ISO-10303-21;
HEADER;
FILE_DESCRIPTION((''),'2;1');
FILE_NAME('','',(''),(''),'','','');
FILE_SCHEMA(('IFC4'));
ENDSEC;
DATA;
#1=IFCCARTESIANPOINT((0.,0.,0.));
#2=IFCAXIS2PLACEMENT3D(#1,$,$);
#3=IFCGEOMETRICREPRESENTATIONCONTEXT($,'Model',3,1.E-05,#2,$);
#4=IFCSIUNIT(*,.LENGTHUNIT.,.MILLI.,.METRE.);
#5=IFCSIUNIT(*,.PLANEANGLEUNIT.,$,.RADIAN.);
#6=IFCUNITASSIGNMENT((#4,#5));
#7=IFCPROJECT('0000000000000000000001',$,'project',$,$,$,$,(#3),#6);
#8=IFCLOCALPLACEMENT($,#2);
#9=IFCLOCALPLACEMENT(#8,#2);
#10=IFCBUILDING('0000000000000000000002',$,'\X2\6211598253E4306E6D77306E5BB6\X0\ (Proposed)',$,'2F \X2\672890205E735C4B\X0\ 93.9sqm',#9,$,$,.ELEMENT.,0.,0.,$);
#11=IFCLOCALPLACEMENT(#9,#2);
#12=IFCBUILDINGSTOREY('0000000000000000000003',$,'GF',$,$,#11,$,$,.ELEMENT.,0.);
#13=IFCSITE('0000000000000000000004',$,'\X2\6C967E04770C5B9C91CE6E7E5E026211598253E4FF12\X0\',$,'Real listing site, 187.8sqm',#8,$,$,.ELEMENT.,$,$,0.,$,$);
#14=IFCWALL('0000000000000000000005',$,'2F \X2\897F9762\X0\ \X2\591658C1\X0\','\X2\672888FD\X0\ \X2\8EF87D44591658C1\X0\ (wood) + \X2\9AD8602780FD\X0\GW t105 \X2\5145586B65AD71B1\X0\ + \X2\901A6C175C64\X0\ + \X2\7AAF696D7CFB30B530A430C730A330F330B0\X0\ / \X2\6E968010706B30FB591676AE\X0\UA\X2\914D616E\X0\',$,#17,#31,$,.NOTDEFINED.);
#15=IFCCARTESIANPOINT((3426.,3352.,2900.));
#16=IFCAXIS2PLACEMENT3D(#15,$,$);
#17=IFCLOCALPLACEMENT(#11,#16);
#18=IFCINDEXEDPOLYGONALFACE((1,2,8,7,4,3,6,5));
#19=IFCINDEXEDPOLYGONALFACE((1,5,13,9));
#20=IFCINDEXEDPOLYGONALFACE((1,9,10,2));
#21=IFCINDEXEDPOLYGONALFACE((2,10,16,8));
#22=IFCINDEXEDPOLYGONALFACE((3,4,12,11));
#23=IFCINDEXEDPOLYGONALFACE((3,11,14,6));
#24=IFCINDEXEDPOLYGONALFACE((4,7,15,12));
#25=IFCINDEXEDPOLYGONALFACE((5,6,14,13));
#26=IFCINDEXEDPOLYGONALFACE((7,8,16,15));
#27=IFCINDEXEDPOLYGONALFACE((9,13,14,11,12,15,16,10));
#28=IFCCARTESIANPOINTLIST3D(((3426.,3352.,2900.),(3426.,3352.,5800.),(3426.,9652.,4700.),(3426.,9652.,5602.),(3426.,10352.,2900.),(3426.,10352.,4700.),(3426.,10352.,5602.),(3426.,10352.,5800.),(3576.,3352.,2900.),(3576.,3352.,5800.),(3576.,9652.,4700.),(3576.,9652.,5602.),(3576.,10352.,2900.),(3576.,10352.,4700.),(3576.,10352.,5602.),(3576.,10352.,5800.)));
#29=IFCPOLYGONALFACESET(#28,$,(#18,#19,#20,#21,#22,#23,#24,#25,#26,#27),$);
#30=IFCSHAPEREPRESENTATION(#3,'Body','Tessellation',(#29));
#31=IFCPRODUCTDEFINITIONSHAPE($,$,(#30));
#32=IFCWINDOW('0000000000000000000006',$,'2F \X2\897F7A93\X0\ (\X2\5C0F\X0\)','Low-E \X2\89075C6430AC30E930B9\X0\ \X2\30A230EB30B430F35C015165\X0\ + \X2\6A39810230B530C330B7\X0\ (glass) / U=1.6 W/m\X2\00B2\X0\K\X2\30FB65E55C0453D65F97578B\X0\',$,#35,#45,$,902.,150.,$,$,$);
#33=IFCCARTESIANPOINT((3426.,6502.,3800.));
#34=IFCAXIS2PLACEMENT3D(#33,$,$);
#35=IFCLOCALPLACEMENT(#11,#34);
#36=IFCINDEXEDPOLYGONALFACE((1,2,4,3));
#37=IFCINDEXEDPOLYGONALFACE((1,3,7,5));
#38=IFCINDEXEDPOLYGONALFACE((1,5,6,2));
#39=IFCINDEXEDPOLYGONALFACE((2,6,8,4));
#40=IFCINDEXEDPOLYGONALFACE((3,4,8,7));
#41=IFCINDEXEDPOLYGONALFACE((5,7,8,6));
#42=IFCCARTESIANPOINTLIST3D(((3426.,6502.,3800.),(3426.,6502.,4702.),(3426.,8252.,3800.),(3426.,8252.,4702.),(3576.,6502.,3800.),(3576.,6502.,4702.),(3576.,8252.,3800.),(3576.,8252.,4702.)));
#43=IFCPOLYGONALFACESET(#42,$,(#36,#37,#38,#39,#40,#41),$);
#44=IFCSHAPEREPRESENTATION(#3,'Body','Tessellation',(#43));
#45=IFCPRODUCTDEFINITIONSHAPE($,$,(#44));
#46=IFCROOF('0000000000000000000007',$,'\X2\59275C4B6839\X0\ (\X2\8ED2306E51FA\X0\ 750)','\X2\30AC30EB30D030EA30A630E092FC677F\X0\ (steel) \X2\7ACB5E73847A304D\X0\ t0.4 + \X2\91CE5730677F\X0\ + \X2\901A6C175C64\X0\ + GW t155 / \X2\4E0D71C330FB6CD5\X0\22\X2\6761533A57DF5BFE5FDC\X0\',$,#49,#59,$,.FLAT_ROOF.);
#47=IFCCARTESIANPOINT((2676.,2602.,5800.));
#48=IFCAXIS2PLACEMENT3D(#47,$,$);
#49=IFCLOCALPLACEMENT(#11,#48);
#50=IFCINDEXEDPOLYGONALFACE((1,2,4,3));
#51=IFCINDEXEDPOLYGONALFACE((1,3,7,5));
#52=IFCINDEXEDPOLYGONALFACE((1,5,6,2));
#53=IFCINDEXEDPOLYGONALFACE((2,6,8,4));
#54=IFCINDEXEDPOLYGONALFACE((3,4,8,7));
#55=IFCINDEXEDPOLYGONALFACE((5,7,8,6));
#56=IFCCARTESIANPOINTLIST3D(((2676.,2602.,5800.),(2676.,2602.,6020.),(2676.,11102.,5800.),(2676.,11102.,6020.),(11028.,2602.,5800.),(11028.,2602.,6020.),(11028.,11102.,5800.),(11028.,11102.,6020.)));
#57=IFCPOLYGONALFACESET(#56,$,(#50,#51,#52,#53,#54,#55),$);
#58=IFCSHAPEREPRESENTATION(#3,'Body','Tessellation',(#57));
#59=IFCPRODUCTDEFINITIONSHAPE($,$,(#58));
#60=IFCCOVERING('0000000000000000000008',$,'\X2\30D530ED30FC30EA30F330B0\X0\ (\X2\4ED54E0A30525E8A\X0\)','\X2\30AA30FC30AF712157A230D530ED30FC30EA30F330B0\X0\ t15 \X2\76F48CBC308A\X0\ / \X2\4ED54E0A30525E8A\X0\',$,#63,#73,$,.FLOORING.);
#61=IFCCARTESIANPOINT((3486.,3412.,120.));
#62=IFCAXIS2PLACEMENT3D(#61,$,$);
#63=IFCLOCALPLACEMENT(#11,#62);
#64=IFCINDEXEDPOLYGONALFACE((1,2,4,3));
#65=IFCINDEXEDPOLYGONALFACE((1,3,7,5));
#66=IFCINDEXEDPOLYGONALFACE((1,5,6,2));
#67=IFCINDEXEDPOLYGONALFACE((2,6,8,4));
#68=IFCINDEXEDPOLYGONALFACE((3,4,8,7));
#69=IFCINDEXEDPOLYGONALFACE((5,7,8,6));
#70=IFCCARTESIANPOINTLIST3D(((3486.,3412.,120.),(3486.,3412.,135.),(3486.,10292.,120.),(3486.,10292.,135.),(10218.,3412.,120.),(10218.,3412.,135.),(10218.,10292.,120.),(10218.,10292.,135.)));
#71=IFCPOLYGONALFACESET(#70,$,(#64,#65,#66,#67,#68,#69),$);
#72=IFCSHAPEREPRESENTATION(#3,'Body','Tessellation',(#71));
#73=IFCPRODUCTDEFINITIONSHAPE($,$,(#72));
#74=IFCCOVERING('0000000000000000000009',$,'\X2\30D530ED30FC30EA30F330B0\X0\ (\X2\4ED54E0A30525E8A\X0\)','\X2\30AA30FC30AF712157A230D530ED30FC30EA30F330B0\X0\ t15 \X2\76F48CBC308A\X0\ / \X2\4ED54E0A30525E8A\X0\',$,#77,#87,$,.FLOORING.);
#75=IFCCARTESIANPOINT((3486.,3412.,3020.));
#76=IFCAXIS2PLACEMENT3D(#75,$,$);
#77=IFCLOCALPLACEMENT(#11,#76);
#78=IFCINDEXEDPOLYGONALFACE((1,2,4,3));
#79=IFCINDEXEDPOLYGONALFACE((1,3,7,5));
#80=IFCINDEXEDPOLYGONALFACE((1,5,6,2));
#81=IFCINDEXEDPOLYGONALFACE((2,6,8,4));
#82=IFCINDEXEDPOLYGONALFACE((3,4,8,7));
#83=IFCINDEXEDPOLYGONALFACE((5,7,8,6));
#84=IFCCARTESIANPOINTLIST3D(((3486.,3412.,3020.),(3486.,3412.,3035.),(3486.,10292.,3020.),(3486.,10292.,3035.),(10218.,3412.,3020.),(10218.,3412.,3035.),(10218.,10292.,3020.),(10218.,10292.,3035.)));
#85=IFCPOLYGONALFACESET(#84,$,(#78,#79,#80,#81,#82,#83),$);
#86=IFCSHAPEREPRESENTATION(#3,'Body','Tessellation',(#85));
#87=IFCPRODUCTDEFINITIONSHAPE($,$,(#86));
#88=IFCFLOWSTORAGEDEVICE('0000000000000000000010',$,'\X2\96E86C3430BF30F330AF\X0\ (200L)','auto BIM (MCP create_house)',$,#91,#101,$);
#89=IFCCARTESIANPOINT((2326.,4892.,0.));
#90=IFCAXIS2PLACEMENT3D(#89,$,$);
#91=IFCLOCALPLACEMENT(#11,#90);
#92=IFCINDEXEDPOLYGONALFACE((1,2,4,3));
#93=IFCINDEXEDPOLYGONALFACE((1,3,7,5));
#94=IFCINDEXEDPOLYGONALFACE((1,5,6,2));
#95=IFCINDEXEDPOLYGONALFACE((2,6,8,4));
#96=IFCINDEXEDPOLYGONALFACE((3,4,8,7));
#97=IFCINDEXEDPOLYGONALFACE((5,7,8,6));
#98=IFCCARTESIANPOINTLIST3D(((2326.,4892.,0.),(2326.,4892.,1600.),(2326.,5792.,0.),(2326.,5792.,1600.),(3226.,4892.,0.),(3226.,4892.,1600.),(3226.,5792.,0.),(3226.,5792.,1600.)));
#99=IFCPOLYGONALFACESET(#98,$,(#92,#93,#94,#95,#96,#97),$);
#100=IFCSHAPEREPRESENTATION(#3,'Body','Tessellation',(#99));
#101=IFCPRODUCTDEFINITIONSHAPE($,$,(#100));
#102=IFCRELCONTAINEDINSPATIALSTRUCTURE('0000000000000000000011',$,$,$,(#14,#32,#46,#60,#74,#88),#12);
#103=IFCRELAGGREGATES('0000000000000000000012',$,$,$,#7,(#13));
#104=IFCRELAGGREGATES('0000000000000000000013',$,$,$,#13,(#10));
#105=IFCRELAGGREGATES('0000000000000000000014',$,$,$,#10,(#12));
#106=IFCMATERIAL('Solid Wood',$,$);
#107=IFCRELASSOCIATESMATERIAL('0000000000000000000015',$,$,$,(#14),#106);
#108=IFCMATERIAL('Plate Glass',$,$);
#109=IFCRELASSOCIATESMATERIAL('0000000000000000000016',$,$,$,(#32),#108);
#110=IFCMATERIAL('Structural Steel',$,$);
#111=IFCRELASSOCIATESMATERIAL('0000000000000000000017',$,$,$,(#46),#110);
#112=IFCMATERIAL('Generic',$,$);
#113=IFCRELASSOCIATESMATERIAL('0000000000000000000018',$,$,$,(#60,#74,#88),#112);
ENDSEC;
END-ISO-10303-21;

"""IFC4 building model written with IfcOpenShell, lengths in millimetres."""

from ifc_helpers import new_model, si_unit, frame, frame_2d, origin, place, context, project, spatial, rectangle, extrude, material, element, fill, save


model = new_model("IFC4")

# Units and contexts
model_context = context("Model", 3, precision=1e-05, world=origin())
ifc_project = project(units=[si_unit("LENGTHUNIT", "METRE", prefix="MILLI"), si_unit("PLANEANGLEUNIT", "RADIAN")], contexts=[model_context])

# Site, building, storey
site_placement = place(None, origin())
site = spatial("IfcSite", under=ifc_project, at=site_placement, Name="沖縄県宜野湾市我如古２", ObjectType="Real listing site, 187.8sqm", CompositionType="ELEMENT", RefElevation=0.0)
building_placement = place(site_placement, origin())
building = spatial("IfcBuilding", under=site, at=building_placement, Name="我如古の海の家 (Proposed)", ObjectType="2F 木造平屋 93.9sqm", CompositionType="ELEMENT", ElevationOfRefHeight=0.0, ElevationOfTerrain=0.0)
storey_placement = place(building_placement, origin())
storey = spatial("IfcBuildingStorey", under=building, at=storey_placement, Name="GF", CompositionType="ELEMENT", Elevation=0.0)

# Shared definitions
ifc_material_1 = material(Name="Solid Wood")

# Shared definitions
ifc_material_2 = material(Name="Plate Glass")

# Wall, opening, window
wall_1_placement = place(storey_placement, frame((3426.0, 3352.0, 2900.0)))
wall_1 = element("IfcWall", 1, at=wall_1_placement, inside=storey, material=ifc_material_1, Name="2F 西面 外壁", Description="木製 軸組外壁 (wood) + 高性能GW t105 充填断熱 + 通気層 + 窯業系サイディング / 準耐火・外皮UA配慮", PredefinedType="NOTDEFINED", context=model_context, shape_type="SweptSolid", body=[
    extrude(rectangle(XDim=150.0, YDim=7000.0, at=frame_2d((75.0, 3500.0))), frame((3426.0, 3352.0, 2900.0)), (0.0, 0.0, 1.0), 2900.0),
])
opening_1_placement = place(storey_placement, frame((3426.0, 6502.0, 3800.0)))
opening_1 = element("IfcOpeningElement", 2, at=opening_1_placement, cuts=wall_1, PredefinedType="NOTDEFINED", context=model_context, shape_type="SweptSolid", body=[
    extrude(rectangle(XDim=150.0, YDim=1750.0, at=frame_2d((75.0, 875.0))), frame((3426.0, 6502.0, 3800.0)), (0.0, 0.0, 1.0), 902.0),
])
window_1_placement = place(storey_placement, frame((3426.0, 6502.0, 3800.0)))
window_1 = element("IfcWindow", 3, at=window_1_placement, inside=storey, material=ifc_material_2, Name="2F 西窓 (小)", Description="Low-E 複層ガラス アルゴン封入 + 樹脂サッシ (glass) / U=1.6 W/m²K・日射取得型", OverallHeight=902.0, OverallWidth=150.0, context=model_context, shape_type="SweptSolid", body=[
    extrude(rectangle(XDim=150.0, YDim=1750.0, at=frame_2d((75.0, 875.0))), frame((3426.0, 6502.0, 3800.0)), (0.0, 0.0, 1.0), 902.0),
])
fill(opening_1, window_1)

# Roof
ifc_material_3 = material(Name="Structural Steel")
roof_placement = place(storey_placement, frame((2676.0, 2602.0, 5800.0)))
element("IfcRoof", 4, at=roof_placement, inside=storey, material=ifc_material_3, Name="大屋根 (軒の出 750)", Description="ガルバリウム鋼板 (steel) 立平葺き t0.4 + 野地板 + 通気層 + GW t155 / 不燃・法22条区域対応", PredefinedType="FLAT_ROOF", context=model_context, shape_type="SweptSolid", body=[
    extrude(rectangle(XDim=8352.0, YDim=8500.0, at=frame_2d((4176.0, 4250.0))), frame((2676.0, 2602.0, 5800.0)), (0.0, 0.0, 1.0), 220.0),
])

# Coverings
ifc_material_4 = material(Name="Generic")
covering_1_placement = place(storey_placement, frame((3486.0, 3412.0, 120.0)))
element("IfcCovering", 5, at=covering_1_placement, inside=storey, material=ifc_material_4, Name="フローリング (仕上げ床)", Description="オーク無垢フローリング t15 直貼り / 仕上げ床", PredefinedType="FLOORING", context=model_context, shape_type="SweptSolid", body=[
    extrude(rectangle(XDim=6732.0, YDim=6880.0, at=frame_2d((3366.0, 3440.0))), frame((3486.0, 3412.0, 120.0)), (0.0, 0.0, 1.0), 15.0),
])
covering_2_placement = place(storey_placement, frame((3486.0, 3412.0, 3020.0)))
element("IfcCovering", 6, at=covering_2_placement, inside=storey, material=ifc_material_4, Name="フローリング (仕上げ床)", Description="オーク無垢フローリング t15 直貼り / 仕上げ床", PredefinedType="FLOORING", context=model_context, shape_type="SweptSolid", body=[
    extrude(rectangle(XDim=6732.0, YDim=6880.0, at=frame_2d((3366.0, 3440.0))), frame((3486.0, 3412.0, 3020.0)), (0.0, 0.0, 1.0), 15.0),
])

# Flow storage device
flow_storage_device_placement = place(storey_placement, frame((2326.0, 4892.0, 0.0)))
element("IfcFlowStorageDevice", 7, at=flow_storage_device_placement, inside=storey, material=ifc_material_4, Name="雨水タンク (200L)", Description="auto BIM (MCP create_house)", context=model_context, shape_type="SweptSolid", body=[
    extrude(rectangle(XDim=900.0, YDim=900.0, at=frame_2d((450.0, 450.0))), frame((2326.0, 4892.0, 0.0)), (0.0, 0.0, 1.0), 1600.0),
])

save(model, "model.ifc")
